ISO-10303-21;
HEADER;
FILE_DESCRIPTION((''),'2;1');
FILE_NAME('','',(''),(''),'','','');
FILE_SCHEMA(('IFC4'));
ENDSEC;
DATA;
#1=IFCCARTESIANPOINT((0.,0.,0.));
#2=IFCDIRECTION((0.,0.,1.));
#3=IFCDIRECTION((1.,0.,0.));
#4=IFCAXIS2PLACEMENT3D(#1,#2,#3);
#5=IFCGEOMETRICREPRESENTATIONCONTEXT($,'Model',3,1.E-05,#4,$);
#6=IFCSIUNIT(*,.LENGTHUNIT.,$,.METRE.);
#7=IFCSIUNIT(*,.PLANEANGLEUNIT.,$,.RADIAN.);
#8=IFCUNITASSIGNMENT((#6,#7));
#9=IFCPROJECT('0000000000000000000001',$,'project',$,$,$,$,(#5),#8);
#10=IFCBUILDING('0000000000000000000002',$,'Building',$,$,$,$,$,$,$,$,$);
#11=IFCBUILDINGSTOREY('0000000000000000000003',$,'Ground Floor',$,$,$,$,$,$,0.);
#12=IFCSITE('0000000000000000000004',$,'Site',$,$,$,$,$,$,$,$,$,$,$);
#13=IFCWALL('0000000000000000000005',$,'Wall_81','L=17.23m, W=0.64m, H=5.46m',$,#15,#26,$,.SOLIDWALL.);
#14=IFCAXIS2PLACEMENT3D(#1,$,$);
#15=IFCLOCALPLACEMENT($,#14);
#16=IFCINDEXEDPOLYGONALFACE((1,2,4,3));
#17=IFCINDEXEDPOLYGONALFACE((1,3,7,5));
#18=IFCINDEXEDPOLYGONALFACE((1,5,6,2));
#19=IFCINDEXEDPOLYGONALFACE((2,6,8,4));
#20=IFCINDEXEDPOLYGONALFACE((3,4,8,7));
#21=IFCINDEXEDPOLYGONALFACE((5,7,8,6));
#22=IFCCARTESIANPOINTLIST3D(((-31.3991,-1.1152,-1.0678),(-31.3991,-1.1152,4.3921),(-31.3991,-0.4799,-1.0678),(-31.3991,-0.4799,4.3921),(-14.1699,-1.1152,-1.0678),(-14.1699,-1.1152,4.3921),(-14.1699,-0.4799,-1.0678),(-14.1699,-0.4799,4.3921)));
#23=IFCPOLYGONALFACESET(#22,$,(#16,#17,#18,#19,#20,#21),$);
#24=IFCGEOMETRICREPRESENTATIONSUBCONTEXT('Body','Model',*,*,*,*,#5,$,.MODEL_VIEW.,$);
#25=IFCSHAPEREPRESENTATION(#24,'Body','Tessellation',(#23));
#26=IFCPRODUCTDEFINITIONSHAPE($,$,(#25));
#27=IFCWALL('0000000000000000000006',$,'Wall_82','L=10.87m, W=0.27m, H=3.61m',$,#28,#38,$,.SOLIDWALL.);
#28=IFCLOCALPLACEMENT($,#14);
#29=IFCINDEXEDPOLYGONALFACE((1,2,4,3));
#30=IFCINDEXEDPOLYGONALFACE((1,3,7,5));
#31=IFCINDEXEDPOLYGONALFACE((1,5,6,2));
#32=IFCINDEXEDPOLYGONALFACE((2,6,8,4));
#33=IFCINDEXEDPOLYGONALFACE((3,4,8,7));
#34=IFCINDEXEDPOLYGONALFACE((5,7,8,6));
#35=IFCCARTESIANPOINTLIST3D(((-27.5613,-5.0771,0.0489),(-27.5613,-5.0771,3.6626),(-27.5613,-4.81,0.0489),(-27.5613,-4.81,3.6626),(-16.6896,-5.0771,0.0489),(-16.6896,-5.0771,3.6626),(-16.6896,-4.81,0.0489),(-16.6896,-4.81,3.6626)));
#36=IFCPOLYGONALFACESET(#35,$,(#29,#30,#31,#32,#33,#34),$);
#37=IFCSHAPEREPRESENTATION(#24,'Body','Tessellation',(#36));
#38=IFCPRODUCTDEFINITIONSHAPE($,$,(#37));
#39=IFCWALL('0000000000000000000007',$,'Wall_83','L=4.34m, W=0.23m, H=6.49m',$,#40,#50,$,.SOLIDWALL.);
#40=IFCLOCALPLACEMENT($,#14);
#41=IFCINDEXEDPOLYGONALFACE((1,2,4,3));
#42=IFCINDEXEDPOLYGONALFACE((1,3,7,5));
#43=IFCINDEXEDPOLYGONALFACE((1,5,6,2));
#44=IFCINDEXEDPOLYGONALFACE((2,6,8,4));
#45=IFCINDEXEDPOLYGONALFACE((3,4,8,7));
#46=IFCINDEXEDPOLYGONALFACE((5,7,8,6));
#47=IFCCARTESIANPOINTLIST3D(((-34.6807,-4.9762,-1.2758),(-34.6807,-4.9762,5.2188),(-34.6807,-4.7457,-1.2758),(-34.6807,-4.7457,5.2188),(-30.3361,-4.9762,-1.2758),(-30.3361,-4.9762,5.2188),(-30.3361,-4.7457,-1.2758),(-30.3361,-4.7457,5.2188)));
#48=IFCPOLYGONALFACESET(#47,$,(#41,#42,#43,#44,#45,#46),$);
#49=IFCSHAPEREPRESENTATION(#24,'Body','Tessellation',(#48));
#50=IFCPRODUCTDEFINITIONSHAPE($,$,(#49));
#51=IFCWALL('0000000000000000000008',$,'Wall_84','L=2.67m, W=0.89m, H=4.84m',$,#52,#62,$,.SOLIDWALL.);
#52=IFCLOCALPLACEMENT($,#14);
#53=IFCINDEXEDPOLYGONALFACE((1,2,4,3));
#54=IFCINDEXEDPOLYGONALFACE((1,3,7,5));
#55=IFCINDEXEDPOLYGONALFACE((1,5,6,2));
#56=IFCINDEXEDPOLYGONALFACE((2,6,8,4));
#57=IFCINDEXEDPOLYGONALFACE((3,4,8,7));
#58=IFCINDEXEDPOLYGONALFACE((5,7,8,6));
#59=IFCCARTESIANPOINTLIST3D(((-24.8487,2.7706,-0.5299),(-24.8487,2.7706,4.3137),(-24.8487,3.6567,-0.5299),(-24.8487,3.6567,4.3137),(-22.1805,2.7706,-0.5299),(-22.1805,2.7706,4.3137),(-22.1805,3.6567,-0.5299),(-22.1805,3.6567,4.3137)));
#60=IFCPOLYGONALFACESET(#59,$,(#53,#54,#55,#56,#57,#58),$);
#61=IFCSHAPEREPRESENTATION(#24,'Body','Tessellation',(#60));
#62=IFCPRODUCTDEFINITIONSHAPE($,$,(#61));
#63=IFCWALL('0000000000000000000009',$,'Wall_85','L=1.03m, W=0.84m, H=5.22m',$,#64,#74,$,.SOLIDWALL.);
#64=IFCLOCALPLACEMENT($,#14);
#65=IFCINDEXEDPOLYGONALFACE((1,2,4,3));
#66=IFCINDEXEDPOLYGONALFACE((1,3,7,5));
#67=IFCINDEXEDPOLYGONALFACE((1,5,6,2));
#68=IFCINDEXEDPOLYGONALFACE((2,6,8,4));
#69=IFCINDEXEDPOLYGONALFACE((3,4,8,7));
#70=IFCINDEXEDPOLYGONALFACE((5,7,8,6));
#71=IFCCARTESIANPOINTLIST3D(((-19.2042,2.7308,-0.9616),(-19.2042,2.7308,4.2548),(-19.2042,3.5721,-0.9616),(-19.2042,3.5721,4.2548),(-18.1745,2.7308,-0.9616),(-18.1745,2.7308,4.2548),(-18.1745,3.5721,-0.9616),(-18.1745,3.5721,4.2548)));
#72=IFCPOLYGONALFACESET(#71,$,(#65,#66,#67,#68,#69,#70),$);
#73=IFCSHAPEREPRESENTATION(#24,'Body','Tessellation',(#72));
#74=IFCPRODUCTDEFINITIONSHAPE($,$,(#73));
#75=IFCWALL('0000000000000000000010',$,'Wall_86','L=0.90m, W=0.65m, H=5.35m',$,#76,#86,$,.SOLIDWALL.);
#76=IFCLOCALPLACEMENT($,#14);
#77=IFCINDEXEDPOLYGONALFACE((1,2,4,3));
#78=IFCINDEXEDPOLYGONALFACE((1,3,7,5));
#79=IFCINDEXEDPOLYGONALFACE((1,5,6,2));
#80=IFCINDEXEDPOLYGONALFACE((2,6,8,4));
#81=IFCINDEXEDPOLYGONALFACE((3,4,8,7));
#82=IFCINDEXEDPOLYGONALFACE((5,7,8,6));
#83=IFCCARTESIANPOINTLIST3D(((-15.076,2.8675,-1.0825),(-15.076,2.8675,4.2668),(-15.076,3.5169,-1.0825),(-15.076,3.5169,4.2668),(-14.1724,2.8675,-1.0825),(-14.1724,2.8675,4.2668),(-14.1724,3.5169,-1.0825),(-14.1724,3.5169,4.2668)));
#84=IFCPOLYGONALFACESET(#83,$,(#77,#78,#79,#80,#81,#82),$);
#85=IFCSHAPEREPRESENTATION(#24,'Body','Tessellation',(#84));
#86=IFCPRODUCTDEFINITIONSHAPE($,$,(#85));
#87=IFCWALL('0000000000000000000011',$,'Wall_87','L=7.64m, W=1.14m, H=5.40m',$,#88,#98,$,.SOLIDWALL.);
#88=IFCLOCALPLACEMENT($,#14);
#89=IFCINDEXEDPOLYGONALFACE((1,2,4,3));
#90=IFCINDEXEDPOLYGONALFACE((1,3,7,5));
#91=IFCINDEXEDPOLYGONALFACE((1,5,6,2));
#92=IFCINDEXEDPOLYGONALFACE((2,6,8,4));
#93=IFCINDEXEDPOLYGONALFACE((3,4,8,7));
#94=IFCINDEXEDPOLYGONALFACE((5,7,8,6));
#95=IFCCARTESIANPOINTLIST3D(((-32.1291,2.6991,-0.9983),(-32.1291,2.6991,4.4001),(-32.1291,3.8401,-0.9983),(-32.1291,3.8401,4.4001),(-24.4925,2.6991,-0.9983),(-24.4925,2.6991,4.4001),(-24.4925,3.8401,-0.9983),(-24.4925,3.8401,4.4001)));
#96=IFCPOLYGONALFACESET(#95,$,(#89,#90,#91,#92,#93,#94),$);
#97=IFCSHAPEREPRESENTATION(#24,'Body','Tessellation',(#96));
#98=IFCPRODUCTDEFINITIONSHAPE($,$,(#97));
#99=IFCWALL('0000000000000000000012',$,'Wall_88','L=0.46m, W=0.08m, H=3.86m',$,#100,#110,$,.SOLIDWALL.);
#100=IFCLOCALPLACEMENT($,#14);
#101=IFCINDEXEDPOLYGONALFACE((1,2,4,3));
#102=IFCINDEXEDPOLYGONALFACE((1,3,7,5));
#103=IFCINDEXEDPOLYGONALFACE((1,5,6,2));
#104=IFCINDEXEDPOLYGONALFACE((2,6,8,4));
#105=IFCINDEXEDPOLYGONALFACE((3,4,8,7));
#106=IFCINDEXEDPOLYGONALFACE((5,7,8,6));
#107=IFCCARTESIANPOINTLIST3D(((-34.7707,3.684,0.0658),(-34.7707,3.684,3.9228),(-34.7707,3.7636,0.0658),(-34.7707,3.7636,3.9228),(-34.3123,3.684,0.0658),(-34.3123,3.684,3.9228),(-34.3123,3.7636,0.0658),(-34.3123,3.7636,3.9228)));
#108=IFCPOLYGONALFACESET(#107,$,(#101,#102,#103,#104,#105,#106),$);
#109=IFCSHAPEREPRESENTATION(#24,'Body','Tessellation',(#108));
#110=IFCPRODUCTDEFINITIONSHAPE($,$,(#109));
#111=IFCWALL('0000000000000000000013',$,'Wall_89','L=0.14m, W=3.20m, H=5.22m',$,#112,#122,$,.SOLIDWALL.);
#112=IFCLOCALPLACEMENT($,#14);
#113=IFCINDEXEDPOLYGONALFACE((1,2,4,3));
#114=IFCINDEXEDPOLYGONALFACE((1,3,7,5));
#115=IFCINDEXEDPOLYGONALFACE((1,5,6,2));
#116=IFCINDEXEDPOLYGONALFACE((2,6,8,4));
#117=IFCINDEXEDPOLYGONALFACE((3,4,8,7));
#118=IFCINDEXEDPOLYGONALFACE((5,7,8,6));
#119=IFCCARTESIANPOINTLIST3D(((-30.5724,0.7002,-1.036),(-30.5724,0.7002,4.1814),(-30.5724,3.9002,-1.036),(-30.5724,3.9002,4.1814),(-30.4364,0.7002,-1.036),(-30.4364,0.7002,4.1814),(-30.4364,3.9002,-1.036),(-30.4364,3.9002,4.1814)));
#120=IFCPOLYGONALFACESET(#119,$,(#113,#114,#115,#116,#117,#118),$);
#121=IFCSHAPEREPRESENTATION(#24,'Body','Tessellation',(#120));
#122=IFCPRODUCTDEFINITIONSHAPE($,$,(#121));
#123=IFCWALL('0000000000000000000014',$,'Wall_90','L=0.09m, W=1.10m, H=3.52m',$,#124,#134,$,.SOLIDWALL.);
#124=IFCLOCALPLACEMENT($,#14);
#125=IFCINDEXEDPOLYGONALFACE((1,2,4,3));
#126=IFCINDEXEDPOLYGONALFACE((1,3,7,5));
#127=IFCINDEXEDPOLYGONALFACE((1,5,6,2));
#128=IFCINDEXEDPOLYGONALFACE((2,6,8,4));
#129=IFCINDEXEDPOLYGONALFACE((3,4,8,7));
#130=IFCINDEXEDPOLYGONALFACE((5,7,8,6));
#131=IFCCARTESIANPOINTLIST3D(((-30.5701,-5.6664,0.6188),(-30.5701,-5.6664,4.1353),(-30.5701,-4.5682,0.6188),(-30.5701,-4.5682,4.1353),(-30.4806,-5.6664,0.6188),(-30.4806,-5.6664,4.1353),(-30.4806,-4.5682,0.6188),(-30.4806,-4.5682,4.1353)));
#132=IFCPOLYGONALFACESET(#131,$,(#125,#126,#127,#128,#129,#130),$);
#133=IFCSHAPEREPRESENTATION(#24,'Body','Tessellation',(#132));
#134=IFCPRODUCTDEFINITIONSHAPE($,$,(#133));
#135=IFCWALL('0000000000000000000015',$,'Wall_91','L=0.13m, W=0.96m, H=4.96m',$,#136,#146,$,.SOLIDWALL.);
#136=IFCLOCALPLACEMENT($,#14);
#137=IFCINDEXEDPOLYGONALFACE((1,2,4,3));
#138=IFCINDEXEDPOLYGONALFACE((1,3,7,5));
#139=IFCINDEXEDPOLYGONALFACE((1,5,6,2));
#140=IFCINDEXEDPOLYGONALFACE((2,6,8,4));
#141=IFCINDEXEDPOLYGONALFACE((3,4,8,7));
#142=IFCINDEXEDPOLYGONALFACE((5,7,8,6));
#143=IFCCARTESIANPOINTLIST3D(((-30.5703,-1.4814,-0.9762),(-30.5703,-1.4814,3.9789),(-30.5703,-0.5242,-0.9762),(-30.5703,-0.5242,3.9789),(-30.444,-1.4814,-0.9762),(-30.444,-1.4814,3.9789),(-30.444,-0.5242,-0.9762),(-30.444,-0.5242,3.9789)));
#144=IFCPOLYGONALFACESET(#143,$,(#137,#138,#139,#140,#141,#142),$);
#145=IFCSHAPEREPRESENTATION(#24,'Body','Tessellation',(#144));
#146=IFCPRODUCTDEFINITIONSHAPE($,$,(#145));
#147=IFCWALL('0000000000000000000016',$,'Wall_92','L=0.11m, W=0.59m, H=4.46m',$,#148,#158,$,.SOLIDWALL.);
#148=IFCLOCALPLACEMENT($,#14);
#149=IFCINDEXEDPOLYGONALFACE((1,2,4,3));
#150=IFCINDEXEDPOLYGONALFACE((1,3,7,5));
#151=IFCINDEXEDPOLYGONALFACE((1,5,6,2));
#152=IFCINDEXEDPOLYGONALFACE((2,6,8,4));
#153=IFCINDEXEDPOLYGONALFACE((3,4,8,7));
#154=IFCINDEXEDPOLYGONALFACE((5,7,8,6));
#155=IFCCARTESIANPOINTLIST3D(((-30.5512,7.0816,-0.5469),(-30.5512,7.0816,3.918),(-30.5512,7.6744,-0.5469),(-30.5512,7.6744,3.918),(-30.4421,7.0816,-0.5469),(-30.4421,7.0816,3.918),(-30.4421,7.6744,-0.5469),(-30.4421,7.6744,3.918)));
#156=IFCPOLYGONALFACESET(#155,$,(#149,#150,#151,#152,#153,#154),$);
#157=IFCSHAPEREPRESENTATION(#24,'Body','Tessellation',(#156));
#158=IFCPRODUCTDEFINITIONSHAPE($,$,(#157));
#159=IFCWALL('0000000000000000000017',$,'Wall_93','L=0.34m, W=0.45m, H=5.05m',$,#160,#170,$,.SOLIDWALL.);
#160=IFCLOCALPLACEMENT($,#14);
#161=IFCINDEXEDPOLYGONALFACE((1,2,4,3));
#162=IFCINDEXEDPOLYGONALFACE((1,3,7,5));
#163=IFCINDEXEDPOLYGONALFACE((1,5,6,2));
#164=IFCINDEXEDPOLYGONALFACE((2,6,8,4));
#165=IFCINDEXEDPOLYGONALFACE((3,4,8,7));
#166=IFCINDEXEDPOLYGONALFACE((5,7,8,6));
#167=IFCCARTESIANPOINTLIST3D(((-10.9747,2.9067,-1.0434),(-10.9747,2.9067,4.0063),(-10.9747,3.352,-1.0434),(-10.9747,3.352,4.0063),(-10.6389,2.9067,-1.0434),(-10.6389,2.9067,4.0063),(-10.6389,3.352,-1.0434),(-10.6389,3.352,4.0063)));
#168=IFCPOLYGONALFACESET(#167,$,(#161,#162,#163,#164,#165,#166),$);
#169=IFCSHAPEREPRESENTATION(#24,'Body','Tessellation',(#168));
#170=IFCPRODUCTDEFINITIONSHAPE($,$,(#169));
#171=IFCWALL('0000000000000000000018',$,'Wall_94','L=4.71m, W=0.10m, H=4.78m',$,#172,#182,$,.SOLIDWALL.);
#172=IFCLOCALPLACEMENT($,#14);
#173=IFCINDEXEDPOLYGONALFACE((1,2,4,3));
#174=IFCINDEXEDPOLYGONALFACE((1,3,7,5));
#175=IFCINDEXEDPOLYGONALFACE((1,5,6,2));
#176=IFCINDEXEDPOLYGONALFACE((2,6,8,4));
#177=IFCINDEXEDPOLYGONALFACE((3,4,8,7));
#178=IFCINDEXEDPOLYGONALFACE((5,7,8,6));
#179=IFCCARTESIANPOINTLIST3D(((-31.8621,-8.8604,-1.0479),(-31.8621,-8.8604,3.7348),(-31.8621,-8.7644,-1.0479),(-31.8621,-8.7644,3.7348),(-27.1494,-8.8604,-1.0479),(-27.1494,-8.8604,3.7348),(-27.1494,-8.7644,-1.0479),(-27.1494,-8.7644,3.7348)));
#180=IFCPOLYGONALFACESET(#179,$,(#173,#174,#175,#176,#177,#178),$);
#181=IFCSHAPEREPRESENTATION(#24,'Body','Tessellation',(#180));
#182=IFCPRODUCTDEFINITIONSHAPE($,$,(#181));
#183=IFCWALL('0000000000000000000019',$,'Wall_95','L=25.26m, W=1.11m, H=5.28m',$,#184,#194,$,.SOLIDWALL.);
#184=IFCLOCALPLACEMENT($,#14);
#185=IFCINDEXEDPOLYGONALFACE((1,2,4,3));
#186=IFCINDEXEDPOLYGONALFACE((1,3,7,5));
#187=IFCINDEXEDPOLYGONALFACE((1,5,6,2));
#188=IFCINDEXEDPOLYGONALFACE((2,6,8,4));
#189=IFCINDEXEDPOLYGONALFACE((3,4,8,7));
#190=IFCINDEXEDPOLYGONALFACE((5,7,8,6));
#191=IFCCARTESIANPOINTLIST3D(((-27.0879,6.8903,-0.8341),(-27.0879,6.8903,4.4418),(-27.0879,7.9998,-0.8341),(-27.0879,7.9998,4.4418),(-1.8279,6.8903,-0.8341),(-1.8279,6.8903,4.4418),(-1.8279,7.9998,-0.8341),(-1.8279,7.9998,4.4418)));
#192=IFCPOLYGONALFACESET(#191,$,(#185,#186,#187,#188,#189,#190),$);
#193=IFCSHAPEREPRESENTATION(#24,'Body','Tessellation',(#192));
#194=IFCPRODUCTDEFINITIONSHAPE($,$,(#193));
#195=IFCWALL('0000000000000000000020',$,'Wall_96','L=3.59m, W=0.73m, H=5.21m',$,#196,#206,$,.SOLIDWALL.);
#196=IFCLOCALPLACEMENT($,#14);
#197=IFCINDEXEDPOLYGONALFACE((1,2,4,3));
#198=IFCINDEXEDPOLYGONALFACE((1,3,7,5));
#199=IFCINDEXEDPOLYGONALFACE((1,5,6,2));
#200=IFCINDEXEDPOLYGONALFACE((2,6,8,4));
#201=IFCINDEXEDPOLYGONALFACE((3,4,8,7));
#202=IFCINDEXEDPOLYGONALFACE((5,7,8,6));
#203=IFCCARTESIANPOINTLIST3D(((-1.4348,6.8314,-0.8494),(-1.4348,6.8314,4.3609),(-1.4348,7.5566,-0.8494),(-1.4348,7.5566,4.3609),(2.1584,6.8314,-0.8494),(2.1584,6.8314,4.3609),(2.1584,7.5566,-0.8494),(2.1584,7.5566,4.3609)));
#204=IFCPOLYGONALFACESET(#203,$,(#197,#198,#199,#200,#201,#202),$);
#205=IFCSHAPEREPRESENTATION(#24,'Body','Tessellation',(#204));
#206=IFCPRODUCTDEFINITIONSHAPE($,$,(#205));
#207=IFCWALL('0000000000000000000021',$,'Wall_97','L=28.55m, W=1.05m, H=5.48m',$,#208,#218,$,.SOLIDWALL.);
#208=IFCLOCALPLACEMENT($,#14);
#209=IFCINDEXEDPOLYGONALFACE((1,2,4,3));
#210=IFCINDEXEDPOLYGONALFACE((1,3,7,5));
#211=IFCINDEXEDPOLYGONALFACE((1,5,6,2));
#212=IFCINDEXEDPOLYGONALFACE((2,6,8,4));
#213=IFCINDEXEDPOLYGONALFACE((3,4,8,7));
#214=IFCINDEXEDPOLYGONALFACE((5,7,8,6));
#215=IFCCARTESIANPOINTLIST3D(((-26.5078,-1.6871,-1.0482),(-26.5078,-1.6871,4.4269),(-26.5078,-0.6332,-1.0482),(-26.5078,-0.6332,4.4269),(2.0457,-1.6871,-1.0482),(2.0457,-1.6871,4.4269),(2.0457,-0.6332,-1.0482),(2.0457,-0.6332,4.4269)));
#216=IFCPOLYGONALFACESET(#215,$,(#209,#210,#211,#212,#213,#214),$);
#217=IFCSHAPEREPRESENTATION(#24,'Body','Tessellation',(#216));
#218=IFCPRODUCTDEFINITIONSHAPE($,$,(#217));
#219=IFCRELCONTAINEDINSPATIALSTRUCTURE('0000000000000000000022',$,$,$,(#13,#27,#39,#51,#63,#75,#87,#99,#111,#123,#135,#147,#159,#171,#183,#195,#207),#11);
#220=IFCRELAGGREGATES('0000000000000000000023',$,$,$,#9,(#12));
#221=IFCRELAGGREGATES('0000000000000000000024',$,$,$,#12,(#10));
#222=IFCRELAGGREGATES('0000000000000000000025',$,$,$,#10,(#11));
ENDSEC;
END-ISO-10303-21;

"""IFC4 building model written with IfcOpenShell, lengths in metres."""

from ifc_helpers import new_model, si_unit, frame, origin_with_axes, origin_2d, context, subcontext, project, spatial, rectangle, extrude, element, save


model = new_model("IFC4")

# Units and contexts
model_context = context("Model", 3, precision=1e-05, world=origin_with_axes())
body_context = subcontext(model_context, "Body", "Model", "MODEL_VIEW")
ifc_project = project(units=[si_unit("LENGTHUNIT", "METRE"), si_unit("PLANEANGLEUNIT", "RADIAN")], contexts=[model_context])

# Site, building, storey
site = spatial("IfcSite", under=ifc_project, Name="Site")
building = spatial("IfcBuilding", under=site, Name="Building")
storey = spatial("IfcBuildingStorey", under=building, Name="Ground Floor", Elevation=0.0)

# Walls
element("IfcWall", 1, inside=storey, Name="Wall_81", Description="L=17.23m, W=0.64m, H=5.46m", PredefinedType="SOLIDWALL", context=body_context, shape_type="SweptSolid", body=[
    extrude(rectangle(XDim=17.2292, YDim=0.6353, at=origin_2d()), frame((-22.7845, -0.7975, -1.0678), z_axis=(0.0, 0.0, 1.0), x_axis=(1.0, 0.0, 0.0)), (0.0, 0.0, 1.0), 5.4599),
])
element("IfcWall", 2, inside=storey, Name="Wall_82", Description="L=10.87m, W=0.27m, H=3.61m", PredefinedType="SOLIDWALL", context=body_context, shape_type="SweptSolid", body=[
    extrude(rectangle(XDim=10.8717, YDim=0.267, at=origin_2d()), frame((-22.1254, -4.9436, 0.0489), z_axis=(0.0, 0.0, 1.0), x_axis=(1.0, 0.0, 0.0)), (0.0, 0.0, 1.0), 3.6137),
])
element("IfcWall", 3, inside=storey, Name="Wall_83", Description="L=4.34m, W=0.23m, H=6.49m", PredefinedType="SOLIDWALL", context=body_context, shape_type="SweptSolid", body=[
    extrude(rectangle(XDim=4.3446, YDim=0.2305, at=origin_2d()), frame((-32.5084, -4.861, -1.2758), z_axis=(0.0, 0.0, 1.0), x_axis=(1.0, 0.0, 0.0)), (0.0, 0.0, 1.0), 6.4946),
])
element("IfcWall", 4, inside=storey, Name="Wall_84", Description="L=2.67m, W=0.89m, H=4.84m", PredefinedType="SOLIDWALL", context=body_context, shape_type="SweptSolid", body=[
    extrude(rectangle(XDim=2.6682, YDim=0.8861, at=origin_2d()), frame((-23.5146, 3.2136, -0.5299), z_axis=(0.0, 0.0, 1.0), x_axis=(1.0, 0.0, 0.0)), (0.0, 0.0, 1.0), 4.8436),
])
element("IfcWall", 5, inside=storey, Name="Wall_85", Description="L=1.03m, W=0.84m, H=5.22m", PredefinedType="SOLIDWALL", context=body_context, shape_type="SweptSolid", body=[
    extrude(rectangle(XDim=1.0297, YDim=0.8412, at=origin_2d()), frame((-18.6894, 3.1514, -0.9616), z_axis=(0.0, 0.0, 1.0), x_axis=(1.0, 0.0, 0.0)), (0.0, 0.0, 1.0), 5.2164),
])
element("IfcWall", 6, inside=storey, Name="Wall_86", Description="L=0.90m, W=0.65m, H=5.35m", PredefinedType="SOLIDWALL", context=body_context, shape_type="SweptSolid", body=[
    extrude(rectangle(XDim=0.9035, YDim=0.6494, at=origin_2d()), frame((-14.6242, 3.1922, -1.0825), z_axis=(0.0, 0.0, 1.0), x_axis=(1.0, 0.0, 0.0)), (0.0, 0.0, 1.0), 5.3493),
])
element("IfcWall", 7, inside=storey, Name="Wall_87", Description="L=7.64m, W=1.14m, H=5.40m", PredefinedType="SOLIDWALL", context=body_context, shape_type="SweptSolid", body=[
    extrude(rectangle(XDim=7.6367, YDim=1.1411, at=origin_2d()), frame((-28.3108, 3.2696, -0.9983), z_axis=(0.0, 0.0, 1.0), x_axis=(1.0, 0.0, 0.0)), (0.0, 0.0, 1.0), 5.3984),
])
element("IfcWall", 8, inside=storey, Name="Wall_88", Description="L=0.46m, W=0.08m, H=3.86m", PredefinedType="SOLIDWALL", context=body_context, shape_type="SweptSolid", body=[
    extrude(rectangle(XDim=0.4584, YDim=0.0796, at=origin_2d()), frame((-34.5415, 3.7238, 0.0658), z_axis=(0.0, 0.0, 1.0), x_axis=(1.0, 0.0, 0.0)), (0.0, 0.0, 1.0), 3.857),
])
element("IfcWall", 9, inside=storey, Name="Wall_89", Description="L=0.14m, W=3.20m, H=5.22m", PredefinedType="SOLIDWALL", context=body_context, shape_type="SweptSolid", body=[
    extrude(rectangle(XDim=0.136, YDim=3.2, at=origin_2d()), frame((-30.5044, 2.3002, -1.036), z_axis=(0.0, 0.0, 1.0), x_axis=(1.0, 0.0, 0.0)), (0.0, 0.0, 1.0), 5.2174),
])
element("IfcWall", 10, inside=storey, Name="Wall_90", Description="L=0.09m, W=1.10m, H=3.52m", PredefinedType="SOLIDWALL", context=body_context, shape_type="SweptSolid", body=[
    extrude(rectangle(XDim=0.0895, YDim=1.0983, at=origin_2d()), frame((-30.5254, -5.1173, 0.6188), z_axis=(0.0, 0.0, 1.0), x_axis=(1.0, 0.0, 0.0)), (0.0, 0.0, 1.0), 3.5166),
])
element("IfcWall", 11, inside=storey, Name="Wall_91", Description="L=0.13m, W=0.96m, H=4.96m", PredefinedType="SOLIDWALL", context=body_context, shape_type="SweptSolid", body=[
    extrude(rectangle(XDim=0.1263, YDim=0.9571, at=origin_2d()), frame((-30.5071, -1.0028, -0.9762), z_axis=(0.0, 0.0, 1.0), x_axis=(1.0, 0.0, 0.0)), (0.0, 0.0, 1.0), 4.9551),
])
element("IfcWall", 12, inside=storey, Name="Wall_92", Description="L=0.11m, W=0.59m, H=4.46m", PredefinedType="SOLIDWALL", context=body_context, shape_type="SweptSolid", body=[
    extrude(rectangle(XDim=0.1091, YDim=0.5928, at=origin_2d()), frame((-30.4967, 7.378, -0.5469), z_axis=(0.0, 0.0, 1.0), x_axis=(1.0, 0.0, 0.0)), (0.0, 0.0, 1.0), 4.4649),
])
element("IfcWall", 13, inside=storey, Name="Wall_93", Description="L=0.34m, W=0.45m, H=5.05m", PredefinedType="SOLIDWALL", context=body_context, shape_type="SweptSolid", body=[
    extrude(rectangle(XDim=0.3358, YDim=0.4454, at=origin_2d()), frame((-10.8068, 3.1293, -1.0434), z_axis=(0.0, 0.0, 1.0), x_axis=(1.0, 0.0, 0.0)), (0.0, 0.0, 1.0), 5.0497),
])
element("IfcWall", 14, inside=storey, Name="Wall_94", Description="L=4.71m, W=0.10m, H=4.78m", PredefinedType="SOLIDWALL", context=body_context, shape_type="SweptSolid", body=[
    extrude(rectangle(XDim=4.7127, YDim=0.0959, at=origin_2d()), frame((-29.5058, -8.8124, -1.0479), z_axis=(0.0, 0.0, 1.0), x_axis=(1.0, 0.0, 0.0)), (0.0, 0.0, 1.0), 4.7827),
])
element("IfcWall", 15, inside=storey, Name="Wall_95", Description="L=25.26m, W=1.11m, H=5.28m", PredefinedType="SOLIDWALL", context=body_context, shape_type="SweptSolid", body=[
    extrude(rectangle(XDim=25.26, YDim=1.1095, at=origin_2d()), frame((-14.4579, 7.4451, -0.8341), z_axis=(0.0, 0.0, 1.0), x_axis=(1.0, 0.0, 0.0)), (0.0, 0.0, 1.0), 5.276),
])
element("IfcWall", 16, inside=storey, Name="Wall_96", Description="L=3.59m, W=0.73m, H=5.21m", PredefinedType="SOLIDWALL", context=body_context, shape_type="SweptSolid", body=[
    extrude(rectangle(XDim=3.5931, YDim=0.7253, at=origin_2d()), frame((0.3618, 7.194, -0.8494), z_axis=(0.0, 0.0, 1.0), x_axis=(1.0, 0.0, 0.0)), (0.0, 0.0, 1.0), 5.2103),
])
element("IfcWall", 17, inside=storey, Name="Wall_97", Description="L=28.55m, W=1.05m, H=5.48m", PredefinedType="SOLIDWALL", context=body_context, shape_type="SweptSolid", body=[
    extrude(rectangle(XDim=28.5534, YDim=1.0539, at=origin_2d()), frame((-12.231, -1.1601, -1.0482), z_axis=(0.0, 0.0, 1.0), x_axis=(1.0, 0.0, 0.0)), (0.0, 0.0, 1.0), 5.4752),
])

save(model, "model.ifc")
